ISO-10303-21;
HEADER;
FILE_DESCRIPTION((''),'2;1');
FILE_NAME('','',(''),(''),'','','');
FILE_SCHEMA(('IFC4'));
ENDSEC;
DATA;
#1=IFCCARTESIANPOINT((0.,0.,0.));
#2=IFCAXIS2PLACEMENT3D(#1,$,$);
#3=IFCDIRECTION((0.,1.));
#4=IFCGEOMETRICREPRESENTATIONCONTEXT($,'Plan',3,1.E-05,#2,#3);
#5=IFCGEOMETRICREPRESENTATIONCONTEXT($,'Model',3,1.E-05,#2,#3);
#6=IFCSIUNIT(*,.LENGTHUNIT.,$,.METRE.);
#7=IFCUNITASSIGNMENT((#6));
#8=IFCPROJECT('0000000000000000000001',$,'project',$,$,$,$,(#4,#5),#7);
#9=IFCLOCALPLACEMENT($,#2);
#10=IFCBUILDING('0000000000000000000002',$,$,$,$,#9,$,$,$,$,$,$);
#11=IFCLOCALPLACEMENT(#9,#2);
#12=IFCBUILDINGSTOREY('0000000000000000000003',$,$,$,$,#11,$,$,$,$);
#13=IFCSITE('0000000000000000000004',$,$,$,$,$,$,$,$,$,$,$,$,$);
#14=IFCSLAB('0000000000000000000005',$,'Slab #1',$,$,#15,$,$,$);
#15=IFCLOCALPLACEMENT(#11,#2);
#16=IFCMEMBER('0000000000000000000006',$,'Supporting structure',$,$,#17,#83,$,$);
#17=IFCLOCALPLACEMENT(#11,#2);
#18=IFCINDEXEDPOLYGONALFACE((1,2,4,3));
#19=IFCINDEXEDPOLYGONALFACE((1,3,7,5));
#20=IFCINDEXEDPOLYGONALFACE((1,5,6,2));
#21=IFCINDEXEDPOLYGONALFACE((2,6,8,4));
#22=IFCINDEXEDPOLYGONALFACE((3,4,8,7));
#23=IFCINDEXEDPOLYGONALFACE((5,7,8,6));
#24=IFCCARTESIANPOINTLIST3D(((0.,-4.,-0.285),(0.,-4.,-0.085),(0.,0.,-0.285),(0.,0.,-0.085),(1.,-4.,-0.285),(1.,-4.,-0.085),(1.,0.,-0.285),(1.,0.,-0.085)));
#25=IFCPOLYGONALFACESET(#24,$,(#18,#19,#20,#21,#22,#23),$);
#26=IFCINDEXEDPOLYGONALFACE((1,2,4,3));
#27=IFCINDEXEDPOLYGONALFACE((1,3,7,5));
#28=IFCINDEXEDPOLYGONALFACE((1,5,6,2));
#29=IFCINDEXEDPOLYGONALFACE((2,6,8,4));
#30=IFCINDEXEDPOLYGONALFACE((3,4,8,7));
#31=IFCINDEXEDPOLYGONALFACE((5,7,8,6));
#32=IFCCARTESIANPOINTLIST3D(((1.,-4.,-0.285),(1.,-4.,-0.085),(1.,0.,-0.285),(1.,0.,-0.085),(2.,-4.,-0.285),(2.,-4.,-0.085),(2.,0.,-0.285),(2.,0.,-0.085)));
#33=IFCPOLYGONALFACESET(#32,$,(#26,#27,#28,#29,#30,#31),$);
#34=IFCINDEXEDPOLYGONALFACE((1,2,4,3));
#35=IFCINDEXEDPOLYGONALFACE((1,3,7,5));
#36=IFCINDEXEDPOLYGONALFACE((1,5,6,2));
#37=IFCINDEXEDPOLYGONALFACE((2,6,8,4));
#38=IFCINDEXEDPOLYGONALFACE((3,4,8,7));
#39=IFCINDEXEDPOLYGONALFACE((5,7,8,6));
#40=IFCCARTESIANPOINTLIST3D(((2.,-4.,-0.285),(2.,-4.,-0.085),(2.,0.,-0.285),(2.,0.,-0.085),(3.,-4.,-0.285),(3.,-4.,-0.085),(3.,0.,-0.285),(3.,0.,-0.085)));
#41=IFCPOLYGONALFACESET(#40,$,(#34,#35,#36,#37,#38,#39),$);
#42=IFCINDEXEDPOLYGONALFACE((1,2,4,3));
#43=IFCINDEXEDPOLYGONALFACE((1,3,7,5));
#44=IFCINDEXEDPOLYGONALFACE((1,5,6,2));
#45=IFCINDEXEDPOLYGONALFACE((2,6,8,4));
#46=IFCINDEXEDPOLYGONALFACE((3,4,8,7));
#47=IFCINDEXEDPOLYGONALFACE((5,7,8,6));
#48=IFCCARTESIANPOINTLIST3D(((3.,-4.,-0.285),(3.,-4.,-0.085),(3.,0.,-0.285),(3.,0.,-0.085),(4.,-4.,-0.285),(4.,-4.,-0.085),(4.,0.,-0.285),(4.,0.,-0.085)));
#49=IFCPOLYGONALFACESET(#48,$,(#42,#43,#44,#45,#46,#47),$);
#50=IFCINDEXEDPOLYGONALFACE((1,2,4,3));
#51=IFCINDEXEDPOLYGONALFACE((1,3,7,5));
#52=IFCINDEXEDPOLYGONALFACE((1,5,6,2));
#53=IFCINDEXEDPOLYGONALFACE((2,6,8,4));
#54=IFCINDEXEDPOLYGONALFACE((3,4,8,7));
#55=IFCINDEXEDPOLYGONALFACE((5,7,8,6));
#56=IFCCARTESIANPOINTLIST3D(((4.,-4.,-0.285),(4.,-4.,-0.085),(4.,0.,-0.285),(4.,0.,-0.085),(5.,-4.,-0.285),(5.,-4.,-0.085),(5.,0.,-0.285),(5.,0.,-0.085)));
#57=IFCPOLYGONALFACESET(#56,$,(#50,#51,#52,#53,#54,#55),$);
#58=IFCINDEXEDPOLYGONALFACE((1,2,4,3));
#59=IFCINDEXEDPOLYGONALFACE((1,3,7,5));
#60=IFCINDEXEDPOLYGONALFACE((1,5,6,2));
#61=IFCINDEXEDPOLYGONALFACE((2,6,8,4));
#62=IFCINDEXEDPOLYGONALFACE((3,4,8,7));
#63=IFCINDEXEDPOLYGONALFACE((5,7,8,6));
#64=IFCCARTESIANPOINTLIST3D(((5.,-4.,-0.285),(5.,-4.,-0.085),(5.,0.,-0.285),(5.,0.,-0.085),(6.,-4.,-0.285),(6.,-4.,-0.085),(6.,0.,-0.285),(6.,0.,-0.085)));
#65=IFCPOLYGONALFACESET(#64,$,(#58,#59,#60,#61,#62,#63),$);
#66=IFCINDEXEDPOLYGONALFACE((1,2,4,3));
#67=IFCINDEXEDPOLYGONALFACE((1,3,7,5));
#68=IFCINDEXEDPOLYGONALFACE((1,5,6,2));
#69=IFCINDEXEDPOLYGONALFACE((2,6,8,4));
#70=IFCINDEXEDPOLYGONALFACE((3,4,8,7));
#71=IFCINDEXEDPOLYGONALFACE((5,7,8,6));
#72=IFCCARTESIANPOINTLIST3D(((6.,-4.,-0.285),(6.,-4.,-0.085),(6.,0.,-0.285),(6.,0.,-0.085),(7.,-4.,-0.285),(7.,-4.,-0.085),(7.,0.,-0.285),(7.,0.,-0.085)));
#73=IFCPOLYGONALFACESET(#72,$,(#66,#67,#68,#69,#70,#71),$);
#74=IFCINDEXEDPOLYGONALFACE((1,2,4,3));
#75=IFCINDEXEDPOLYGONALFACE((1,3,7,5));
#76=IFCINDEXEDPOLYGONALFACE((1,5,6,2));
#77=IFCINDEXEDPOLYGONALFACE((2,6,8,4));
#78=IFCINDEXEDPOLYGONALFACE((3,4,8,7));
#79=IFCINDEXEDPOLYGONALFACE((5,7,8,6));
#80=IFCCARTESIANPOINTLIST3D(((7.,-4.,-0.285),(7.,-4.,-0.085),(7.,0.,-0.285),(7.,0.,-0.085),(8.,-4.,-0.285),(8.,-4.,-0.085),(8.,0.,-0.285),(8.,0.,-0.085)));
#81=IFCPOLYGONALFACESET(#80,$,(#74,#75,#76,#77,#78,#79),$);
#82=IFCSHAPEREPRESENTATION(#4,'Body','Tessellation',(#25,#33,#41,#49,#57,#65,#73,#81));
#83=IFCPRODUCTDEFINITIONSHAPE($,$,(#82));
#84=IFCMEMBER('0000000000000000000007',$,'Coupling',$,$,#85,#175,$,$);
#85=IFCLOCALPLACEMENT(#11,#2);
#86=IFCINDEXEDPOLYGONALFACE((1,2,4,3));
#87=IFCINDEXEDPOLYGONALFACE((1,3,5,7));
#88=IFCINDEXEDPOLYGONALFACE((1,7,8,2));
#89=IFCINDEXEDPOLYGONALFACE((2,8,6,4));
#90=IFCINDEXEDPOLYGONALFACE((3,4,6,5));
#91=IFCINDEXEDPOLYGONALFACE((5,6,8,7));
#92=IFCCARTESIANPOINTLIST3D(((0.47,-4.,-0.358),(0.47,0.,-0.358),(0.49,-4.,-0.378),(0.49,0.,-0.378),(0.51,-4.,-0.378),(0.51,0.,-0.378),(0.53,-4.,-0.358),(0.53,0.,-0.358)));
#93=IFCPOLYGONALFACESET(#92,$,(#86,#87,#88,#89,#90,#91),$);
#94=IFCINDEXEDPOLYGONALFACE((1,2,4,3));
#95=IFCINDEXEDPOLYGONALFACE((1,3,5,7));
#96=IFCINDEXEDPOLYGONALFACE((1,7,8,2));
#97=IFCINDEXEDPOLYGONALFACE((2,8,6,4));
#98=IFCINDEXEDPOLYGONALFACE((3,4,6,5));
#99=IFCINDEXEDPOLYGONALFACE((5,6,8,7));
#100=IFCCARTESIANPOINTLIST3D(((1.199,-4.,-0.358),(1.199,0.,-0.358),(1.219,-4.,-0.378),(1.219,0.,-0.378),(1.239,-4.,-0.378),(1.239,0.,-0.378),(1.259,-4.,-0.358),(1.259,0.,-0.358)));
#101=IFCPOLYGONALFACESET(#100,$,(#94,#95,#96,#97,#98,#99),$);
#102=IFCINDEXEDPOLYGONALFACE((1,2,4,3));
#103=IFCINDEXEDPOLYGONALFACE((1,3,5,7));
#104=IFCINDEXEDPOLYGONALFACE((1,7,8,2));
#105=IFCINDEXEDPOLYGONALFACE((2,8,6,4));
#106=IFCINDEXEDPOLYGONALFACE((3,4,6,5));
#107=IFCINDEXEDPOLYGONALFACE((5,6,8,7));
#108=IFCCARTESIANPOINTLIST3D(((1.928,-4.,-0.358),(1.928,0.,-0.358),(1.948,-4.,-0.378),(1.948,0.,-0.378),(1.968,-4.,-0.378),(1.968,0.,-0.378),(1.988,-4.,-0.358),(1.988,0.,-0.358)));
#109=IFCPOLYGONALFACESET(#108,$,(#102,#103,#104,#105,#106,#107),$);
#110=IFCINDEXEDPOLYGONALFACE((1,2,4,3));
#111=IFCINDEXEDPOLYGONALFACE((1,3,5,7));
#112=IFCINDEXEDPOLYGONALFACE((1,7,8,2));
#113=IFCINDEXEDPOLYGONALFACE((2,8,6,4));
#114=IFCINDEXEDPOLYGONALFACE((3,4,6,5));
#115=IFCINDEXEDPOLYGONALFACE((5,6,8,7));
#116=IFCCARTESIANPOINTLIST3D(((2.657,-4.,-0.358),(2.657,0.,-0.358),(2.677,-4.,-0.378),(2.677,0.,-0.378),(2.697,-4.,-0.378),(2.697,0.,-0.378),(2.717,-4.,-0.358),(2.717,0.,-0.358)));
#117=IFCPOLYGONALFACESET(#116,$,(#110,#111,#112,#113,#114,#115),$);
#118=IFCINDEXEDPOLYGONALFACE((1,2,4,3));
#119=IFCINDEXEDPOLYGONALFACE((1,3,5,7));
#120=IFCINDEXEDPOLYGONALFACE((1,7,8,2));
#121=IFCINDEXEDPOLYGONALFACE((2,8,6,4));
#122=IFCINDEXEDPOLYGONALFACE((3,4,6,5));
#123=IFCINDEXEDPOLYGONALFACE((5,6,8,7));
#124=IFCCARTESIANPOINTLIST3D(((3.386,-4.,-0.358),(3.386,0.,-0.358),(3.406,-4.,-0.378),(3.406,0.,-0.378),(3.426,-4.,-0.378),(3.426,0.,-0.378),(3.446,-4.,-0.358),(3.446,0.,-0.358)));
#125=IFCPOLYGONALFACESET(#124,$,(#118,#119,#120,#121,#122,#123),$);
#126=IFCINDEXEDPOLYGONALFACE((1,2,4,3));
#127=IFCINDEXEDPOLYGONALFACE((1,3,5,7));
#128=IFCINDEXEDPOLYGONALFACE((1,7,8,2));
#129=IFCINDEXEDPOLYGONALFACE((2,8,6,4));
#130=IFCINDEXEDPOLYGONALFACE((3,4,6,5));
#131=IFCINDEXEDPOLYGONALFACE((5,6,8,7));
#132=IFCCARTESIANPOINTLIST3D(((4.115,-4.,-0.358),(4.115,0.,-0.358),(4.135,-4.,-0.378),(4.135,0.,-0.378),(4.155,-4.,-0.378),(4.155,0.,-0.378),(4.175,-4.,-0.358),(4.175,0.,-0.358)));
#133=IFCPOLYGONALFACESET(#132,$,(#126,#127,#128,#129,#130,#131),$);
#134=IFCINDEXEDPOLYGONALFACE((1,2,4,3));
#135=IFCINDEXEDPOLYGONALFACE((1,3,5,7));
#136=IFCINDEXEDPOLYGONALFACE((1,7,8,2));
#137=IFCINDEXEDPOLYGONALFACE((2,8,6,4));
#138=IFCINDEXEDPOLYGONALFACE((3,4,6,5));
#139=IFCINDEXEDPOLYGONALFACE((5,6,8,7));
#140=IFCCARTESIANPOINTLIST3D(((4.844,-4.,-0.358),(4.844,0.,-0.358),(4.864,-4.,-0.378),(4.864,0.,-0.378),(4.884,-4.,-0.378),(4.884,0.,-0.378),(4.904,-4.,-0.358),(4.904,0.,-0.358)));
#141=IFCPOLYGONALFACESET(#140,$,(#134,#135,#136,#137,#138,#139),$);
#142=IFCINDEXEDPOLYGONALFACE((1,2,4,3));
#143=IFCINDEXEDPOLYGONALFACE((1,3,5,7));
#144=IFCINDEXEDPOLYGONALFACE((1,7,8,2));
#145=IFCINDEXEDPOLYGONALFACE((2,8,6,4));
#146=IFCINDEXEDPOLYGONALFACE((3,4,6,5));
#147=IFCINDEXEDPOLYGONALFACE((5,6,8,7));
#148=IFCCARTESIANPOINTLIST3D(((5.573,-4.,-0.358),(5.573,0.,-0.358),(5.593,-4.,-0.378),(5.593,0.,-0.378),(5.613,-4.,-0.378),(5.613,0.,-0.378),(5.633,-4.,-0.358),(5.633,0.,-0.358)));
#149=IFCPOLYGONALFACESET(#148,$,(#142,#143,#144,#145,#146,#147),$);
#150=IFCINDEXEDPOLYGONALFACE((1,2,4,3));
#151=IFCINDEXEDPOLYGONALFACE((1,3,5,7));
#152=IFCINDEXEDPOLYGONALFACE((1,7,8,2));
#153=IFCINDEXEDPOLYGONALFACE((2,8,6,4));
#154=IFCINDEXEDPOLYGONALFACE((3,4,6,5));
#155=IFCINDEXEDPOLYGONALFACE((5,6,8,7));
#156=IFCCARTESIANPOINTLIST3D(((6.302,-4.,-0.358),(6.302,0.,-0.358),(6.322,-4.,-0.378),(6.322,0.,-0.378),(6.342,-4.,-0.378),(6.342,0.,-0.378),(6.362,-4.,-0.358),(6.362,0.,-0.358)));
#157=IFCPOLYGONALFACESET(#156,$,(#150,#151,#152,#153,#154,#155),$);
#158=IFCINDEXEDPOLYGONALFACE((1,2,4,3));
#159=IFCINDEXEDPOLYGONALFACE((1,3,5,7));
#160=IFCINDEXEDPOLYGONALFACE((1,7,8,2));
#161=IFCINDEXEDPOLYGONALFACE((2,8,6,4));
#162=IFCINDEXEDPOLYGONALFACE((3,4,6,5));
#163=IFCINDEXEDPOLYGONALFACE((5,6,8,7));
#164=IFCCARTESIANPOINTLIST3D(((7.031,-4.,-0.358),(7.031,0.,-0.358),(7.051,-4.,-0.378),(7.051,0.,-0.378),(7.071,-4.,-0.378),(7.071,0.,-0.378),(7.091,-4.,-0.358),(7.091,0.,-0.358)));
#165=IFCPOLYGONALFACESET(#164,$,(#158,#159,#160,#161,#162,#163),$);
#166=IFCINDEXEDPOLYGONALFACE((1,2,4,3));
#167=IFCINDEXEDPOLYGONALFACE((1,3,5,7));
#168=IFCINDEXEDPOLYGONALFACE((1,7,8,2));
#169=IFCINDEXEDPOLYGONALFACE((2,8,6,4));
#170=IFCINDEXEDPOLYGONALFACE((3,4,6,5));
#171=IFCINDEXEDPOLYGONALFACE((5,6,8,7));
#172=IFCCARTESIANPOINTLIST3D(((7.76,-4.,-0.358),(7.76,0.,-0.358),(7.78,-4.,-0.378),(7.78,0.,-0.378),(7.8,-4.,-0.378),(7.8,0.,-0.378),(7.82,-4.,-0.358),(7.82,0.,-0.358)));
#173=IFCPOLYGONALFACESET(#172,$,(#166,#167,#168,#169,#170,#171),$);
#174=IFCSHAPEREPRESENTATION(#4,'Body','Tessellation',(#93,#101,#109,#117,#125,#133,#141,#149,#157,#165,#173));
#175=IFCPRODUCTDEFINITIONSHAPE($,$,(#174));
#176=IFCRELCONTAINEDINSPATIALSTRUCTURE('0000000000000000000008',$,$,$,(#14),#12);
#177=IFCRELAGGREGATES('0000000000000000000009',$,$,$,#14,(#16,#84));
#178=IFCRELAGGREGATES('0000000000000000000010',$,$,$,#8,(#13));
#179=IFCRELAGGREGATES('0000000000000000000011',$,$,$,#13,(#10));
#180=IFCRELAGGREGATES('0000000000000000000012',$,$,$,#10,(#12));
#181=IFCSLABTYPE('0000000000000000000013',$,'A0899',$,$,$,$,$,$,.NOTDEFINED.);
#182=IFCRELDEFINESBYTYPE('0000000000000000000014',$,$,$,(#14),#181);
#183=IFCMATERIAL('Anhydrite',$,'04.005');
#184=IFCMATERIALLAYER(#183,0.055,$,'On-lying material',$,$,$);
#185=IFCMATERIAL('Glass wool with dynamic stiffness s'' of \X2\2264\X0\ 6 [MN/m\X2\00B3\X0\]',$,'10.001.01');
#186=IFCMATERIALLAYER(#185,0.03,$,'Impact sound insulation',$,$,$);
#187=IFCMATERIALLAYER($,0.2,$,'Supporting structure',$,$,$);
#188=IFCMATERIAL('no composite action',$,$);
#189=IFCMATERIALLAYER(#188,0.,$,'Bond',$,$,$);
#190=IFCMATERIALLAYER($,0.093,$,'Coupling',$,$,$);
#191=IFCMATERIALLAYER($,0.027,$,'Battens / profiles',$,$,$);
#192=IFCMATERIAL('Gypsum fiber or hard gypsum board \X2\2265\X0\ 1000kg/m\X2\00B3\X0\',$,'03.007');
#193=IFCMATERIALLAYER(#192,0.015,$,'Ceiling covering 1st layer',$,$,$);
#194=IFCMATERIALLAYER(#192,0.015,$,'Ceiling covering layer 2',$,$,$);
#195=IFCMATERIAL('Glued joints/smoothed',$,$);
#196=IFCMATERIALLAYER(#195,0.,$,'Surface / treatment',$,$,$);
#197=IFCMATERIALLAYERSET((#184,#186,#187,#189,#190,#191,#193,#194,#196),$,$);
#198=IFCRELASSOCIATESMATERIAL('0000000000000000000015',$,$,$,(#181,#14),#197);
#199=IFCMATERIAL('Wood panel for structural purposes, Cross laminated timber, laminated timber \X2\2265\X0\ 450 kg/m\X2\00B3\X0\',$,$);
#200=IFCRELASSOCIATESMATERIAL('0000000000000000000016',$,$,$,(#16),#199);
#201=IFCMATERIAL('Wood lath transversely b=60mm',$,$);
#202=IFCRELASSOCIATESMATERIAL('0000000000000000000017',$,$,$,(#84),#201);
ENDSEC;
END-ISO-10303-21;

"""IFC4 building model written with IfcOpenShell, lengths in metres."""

from ifc_helpers import new_model, si_unit, direction, frame, frame_2d, origin, place, context, project, spatial, polyline, rectangle, outline, extrude, material, layer, layer_set, type_object, element, aggregate, save


model = new_model("IFC4")

# Units and contexts
plan_context = context("Plan", 3, precision=1e-05, world=origin(), true_north=direction((0.0, 1.0)))
model_context = context("Model", 3, precision=1e-05, world=origin(), true_north=direction((0.0, 1.0)))
ifc_project = project(units=[si_unit("LENGTHUNIT", "METRE")], contexts=[plan_context, model_context])

# Site, building, storey
site = spatial("IfcSite", under=ifc_project)
building_placement = place(None, origin())
building = spatial("IfcBuilding", under=site, at=building_placement)
storey_placement = place(building_placement, origin())
storey = spatial("IfcBuildingStorey", under=building, at=storey_placement)

# Slab, members
ifc_material_1 = material(Name="Anhydrite", Category="04.005")
ifc_layer_1 = layer(ifc_material_1, 0.055, Name="On-lying material")
ifc_material_2 = material(Name="Glass wool with dynamic stiffness s' of ≤ 6 [MN/m³]", Category="10.001.01")
ifc_layer_2 = layer(ifc_material_2, 0.03, Name="Impact sound insulation")
ifc_layer_3 = layer(None, 0.2, Name="Supporting structure")
ifc_material_3 = material(Name="no composite action")
ifc_layer_4 = layer(ifc_material_3, 0.0, Name="Bond")
ifc_layer_5 = layer(None, 0.093, Name="Coupling")
ifc_layer_6 = layer(None, 0.027, Name="Battens / profiles")
ifc_material_4 = material(Name="Gypsum fiber or hard gypsum board ≥ 1000kg/m³", Category="03.007")
ifc_layer_7 = layer(ifc_material_4, 0.015, Name="Ceiling covering 1st layer")
ifc_layer_8 = layer(ifc_material_4, 0.015, Name="Ceiling covering layer 2")
ifc_material_5 = material(Name="Glued joints/smoothed")
ifc_layer_9 = layer(ifc_material_5, 0.0, Name="Surface / treatment")
ifc_layer_set = layer_set([ifc_layer_1, ifc_layer_2, ifc_layer_3, ifc_layer_4, ifc_layer_5, ifc_layer_6, ifc_layer_7, ifc_layer_8, ifc_layer_9])
slab_type = type_object("IfcSlabType", Name="A0899", PredefinedType="NOTDEFINED", material=ifc_layer_set)
slab_placement = place(None, frame((0.0, 0.0, 0.0), z_axis=(0.0, 0.0, -1.0), x_axis=(1.0, 0.0, 0.0)))
slab = element("IfcSlab", 1, at=slab_placement, inside=storey, type_object=slab_type, material=ifc_layer_set, Name="Slab #1")
ifc_material_6 = material(Name="Wood panel for structural purposes, Cross laminated timber, laminated timber ≥ 450 kg/m³")
member_1_placement = place(slab_placement, origin())
member_1 = element("IfcMember", 2, at=member_1_placement, material=ifc_material_6, Name="Supporting structure", context=plan_context, shape_type="SweptSolid", body=[
    extrude(rectangle(XDim=1.0, YDim=0.2, at=frame_2d((0.5, 0.1), x_axis=(1.0, 0.0))), frame((0.0, 4.0, 0.085), z_axis=(0.0, -1.0, 0.0), x_axis=(1.0, 0.0, 0.0)), (0.0, 0.0, 1.0), 4.0),
    extrude(rectangle(XDim=1.0, YDim=0.2, at=frame_2d((0.5, 0.1), x_axis=(1.0, 0.0))), frame((1.0, 4.0, 0.085), z_axis=(0.0, -1.0, 0.0), x_axis=(1.0, 0.0, 0.0)), (0.0, 0.0, 1.0), 4.0),
    extrude(rectangle(XDim=1.0, YDim=0.2, at=frame_2d((0.5, 0.1), x_axis=(1.0, 0.0))), frame((2.0, 4.0, 0.085), z_axis=(0.0, -1.0, 0.0), x_axis=(1.0, 0.0, 0.0)), (0.0, 0.0, 1.0), 4.0),
    extrude(rectangle(XDim=1.0, YDim=0.2, at=frame_2d((0.5, 0.1), x_axis=(1.0, 0.0))), frame((3.0, 4.0, 0.085), z_axis=(0.0, -1.0, 0.0), x_axis=(1.0, 0.0, 0.0)), (0.0, 0.0, 1.0), 4.0),
    extrude(rectangle(XDim=1.0, YDim=0.2, at=frame_2d((0.5, 0.1), x_axis=(1.0, 0.0))), frame((4.0, 4.0, 0.085), z_axis=(0.0, -1.0, 0.0), x_axis=(1.0, 0.0, 0.0)), (0.0, 0.0, 1.0), 4.0),
    extrude(rectangle(XDim=1.0, YDim=0.2, at=frame_2d((0.5, 0.1), x_axis=(1.0, 0.0))), frame((5.0, 4.0, 0.085), z_axis=(0.0, -1.0, 0.0), x_axis=(1.0, 0.0, 0.0)), (0.0, 0.0, 1.0), 4.0),
    extrude(rectangle(XDim=1.0, YDim=0.2, at=frame_2d((0.5, 0.1), x_axis=(1.0, 0.0))), frame((6.0, 4.0, 0.085), z_axis=(0.0, -1.0, 0.0), x_axis=(1.0, 0.0, 0.0)), (0.0, 0.0, 1.0), 4.0),
    extrude(rectangle(XDim=1.0, YDim=0.2, at=frame_2d((0.5, 0.1), x_axis=(1.0, 0.0))), frame((7.0, 4.0, 0.085), z_axis=(0.0, -1.0, 0.0), x_axis=(1.0, 0.0, 0.0)), (0.0, 0.0, 1.0), 4.0),
])
ifc_material_7 = material(Name="Wood lath transversely b=60mm")
member_2_placement = place(slab_placement, origin())
member_2 = element("IfcMember", 3, at=member_2_placement, material=ifc_material_7, Name="Coupling", context=plan_context, shape_type="SweptSolid", body=[
    extrude(outline(polyline([(0.0, 0.0), (0.06, 0.0), (0.04, 0.02), (0.02, 0.02), (0.0, 0.0)])), frame((0.47, 4.0, 0.358), z_axis=(0.0, -1.0, 0.0), x_axis=(1.0, 0.0, 0.0)), (0.0, 0.0, 1.0), 4.0),
    extrude(outline(polyline([(0.0, 0.0), (0.06, 0.0), (0.04, 0.02), (0.02, 0.02), (0.0, 0.0)])), frame((1.199, 4.0, 0.358), z_axis=(0.0, -1.0, 0.0), x_axis=(1.0, 0.0, 0.0)), (0.0, 0.0, 1.0), 4.0),
    extrude(outline(polyline([(0.0, 0.0), (0.06, 0.0), (0.04, 0.02), (0.02, 0.02), (0.0, 0.0)])), frame((1.928, 4.0, 0.358), z_axis=(0.0, -1.0, 0.0), x_axis=(1.0, 0.0, 0.0)), (0.0, 0.0, 1.0), 4.0),
    extrude(outline(polyline([(0.0, 0.0), (0.06, 0.0), (0.04, 0.02), (0.02, 0.02), (0.0, 0.0)])), frame((2.657, 4.0, 0.358), z_axis=(0.0, -1.0, 0.0), x_axis=(1.0, 0.0, 0.0)), (0.0, 0.0, 1.0), 4.0),
    extrude(outline(polyline([(0.0, 0.0), (0.06, 0.0), (0.04, 0.02), (0.02, 0.02), (0.0, 0.0)])), frame((3.386, 4.0, 0.358), z_axis=(0.0, -1.0, 0.0), x_axis=(1.0, 0.0, 0.0)), (0.0, 0.0, 1.0), 4.0),
    extrude(outline(polyline([(0.0, 0.0), (0.06, 0.0), (0.04, 0.02), (0.02, 0.02), (0.0, 0.0)])), frame((4.115, 4.0, 0.358), z_axis=(0.0, -1.0, 0.0), x_axis=(1.0, 0.0, 0.0)), (0.0, 0.0, 1.0), 4.0),
    extrude(outline(polyline([(0.0, 0.0), (0.06, 0.0), (0.04, 0.02), (0.02, 0.02), (0.0, 0.0)])), frame((4.844, 4.0, 0.358), z_axis=(0.0, -1.0, 0.0), x_axis=(1.0, 0.0, 0.0)), (0.0, 0.0, 1.0), 4.0),
    extrude(outline(polyline([(0.0, 0.0), (0.06, 0.0), (0.04, 0.02), (0.02, 0.02), (0.0, 0.0)])), frame((5.573, 4.0, 0.358), z_axis=(0.0, -1.0, 0.0), x_axis=(1.0, 0.0, 0.0)), (0.0, 0.0, 1.0), 4.0),
    extrude(outline(polyline([(0.0, 0.0), (0.06, 0.0), (0.04, 0.02), (0.02, 0.02), (0.0, 0.0)])), frame((6.302, 4.0, 0.358), z_axis=(0.0, -1.0, 0.0), x_axis=(1.0, 0.0, 0.0)), (0.0, 0.0, 1.0), 4.0),
    extrude(outline(polyline([(0.0, 0.0), (0.06, 0.0), (0.04, 0.02), (0.02, 0.02), (0.0, 0.0)])), frame((7.031, 4.0, 0.358), z_axis=(0.0, -1.0, 0.0), x_axis=(1.0, 0.0, 0.0)), (0.0, 0.0, 1.0), 4.0),
    extrude(outline(polyline([(0.0, 0.0), (0.06, 0.0), (0.04, 0.02), (0.02, 0.02), (0.0, 0.0)])), frame((7.76, 4.0, 0.358), z_axis=(0.0, -1.0, 0.0), x_axis=(1.0, 0.0, 0.0)), (0.0, 0.0, 1.0), 4.0),
])
aggregate(slab, [member_1, member_2])

save(model, "model.ifc")
